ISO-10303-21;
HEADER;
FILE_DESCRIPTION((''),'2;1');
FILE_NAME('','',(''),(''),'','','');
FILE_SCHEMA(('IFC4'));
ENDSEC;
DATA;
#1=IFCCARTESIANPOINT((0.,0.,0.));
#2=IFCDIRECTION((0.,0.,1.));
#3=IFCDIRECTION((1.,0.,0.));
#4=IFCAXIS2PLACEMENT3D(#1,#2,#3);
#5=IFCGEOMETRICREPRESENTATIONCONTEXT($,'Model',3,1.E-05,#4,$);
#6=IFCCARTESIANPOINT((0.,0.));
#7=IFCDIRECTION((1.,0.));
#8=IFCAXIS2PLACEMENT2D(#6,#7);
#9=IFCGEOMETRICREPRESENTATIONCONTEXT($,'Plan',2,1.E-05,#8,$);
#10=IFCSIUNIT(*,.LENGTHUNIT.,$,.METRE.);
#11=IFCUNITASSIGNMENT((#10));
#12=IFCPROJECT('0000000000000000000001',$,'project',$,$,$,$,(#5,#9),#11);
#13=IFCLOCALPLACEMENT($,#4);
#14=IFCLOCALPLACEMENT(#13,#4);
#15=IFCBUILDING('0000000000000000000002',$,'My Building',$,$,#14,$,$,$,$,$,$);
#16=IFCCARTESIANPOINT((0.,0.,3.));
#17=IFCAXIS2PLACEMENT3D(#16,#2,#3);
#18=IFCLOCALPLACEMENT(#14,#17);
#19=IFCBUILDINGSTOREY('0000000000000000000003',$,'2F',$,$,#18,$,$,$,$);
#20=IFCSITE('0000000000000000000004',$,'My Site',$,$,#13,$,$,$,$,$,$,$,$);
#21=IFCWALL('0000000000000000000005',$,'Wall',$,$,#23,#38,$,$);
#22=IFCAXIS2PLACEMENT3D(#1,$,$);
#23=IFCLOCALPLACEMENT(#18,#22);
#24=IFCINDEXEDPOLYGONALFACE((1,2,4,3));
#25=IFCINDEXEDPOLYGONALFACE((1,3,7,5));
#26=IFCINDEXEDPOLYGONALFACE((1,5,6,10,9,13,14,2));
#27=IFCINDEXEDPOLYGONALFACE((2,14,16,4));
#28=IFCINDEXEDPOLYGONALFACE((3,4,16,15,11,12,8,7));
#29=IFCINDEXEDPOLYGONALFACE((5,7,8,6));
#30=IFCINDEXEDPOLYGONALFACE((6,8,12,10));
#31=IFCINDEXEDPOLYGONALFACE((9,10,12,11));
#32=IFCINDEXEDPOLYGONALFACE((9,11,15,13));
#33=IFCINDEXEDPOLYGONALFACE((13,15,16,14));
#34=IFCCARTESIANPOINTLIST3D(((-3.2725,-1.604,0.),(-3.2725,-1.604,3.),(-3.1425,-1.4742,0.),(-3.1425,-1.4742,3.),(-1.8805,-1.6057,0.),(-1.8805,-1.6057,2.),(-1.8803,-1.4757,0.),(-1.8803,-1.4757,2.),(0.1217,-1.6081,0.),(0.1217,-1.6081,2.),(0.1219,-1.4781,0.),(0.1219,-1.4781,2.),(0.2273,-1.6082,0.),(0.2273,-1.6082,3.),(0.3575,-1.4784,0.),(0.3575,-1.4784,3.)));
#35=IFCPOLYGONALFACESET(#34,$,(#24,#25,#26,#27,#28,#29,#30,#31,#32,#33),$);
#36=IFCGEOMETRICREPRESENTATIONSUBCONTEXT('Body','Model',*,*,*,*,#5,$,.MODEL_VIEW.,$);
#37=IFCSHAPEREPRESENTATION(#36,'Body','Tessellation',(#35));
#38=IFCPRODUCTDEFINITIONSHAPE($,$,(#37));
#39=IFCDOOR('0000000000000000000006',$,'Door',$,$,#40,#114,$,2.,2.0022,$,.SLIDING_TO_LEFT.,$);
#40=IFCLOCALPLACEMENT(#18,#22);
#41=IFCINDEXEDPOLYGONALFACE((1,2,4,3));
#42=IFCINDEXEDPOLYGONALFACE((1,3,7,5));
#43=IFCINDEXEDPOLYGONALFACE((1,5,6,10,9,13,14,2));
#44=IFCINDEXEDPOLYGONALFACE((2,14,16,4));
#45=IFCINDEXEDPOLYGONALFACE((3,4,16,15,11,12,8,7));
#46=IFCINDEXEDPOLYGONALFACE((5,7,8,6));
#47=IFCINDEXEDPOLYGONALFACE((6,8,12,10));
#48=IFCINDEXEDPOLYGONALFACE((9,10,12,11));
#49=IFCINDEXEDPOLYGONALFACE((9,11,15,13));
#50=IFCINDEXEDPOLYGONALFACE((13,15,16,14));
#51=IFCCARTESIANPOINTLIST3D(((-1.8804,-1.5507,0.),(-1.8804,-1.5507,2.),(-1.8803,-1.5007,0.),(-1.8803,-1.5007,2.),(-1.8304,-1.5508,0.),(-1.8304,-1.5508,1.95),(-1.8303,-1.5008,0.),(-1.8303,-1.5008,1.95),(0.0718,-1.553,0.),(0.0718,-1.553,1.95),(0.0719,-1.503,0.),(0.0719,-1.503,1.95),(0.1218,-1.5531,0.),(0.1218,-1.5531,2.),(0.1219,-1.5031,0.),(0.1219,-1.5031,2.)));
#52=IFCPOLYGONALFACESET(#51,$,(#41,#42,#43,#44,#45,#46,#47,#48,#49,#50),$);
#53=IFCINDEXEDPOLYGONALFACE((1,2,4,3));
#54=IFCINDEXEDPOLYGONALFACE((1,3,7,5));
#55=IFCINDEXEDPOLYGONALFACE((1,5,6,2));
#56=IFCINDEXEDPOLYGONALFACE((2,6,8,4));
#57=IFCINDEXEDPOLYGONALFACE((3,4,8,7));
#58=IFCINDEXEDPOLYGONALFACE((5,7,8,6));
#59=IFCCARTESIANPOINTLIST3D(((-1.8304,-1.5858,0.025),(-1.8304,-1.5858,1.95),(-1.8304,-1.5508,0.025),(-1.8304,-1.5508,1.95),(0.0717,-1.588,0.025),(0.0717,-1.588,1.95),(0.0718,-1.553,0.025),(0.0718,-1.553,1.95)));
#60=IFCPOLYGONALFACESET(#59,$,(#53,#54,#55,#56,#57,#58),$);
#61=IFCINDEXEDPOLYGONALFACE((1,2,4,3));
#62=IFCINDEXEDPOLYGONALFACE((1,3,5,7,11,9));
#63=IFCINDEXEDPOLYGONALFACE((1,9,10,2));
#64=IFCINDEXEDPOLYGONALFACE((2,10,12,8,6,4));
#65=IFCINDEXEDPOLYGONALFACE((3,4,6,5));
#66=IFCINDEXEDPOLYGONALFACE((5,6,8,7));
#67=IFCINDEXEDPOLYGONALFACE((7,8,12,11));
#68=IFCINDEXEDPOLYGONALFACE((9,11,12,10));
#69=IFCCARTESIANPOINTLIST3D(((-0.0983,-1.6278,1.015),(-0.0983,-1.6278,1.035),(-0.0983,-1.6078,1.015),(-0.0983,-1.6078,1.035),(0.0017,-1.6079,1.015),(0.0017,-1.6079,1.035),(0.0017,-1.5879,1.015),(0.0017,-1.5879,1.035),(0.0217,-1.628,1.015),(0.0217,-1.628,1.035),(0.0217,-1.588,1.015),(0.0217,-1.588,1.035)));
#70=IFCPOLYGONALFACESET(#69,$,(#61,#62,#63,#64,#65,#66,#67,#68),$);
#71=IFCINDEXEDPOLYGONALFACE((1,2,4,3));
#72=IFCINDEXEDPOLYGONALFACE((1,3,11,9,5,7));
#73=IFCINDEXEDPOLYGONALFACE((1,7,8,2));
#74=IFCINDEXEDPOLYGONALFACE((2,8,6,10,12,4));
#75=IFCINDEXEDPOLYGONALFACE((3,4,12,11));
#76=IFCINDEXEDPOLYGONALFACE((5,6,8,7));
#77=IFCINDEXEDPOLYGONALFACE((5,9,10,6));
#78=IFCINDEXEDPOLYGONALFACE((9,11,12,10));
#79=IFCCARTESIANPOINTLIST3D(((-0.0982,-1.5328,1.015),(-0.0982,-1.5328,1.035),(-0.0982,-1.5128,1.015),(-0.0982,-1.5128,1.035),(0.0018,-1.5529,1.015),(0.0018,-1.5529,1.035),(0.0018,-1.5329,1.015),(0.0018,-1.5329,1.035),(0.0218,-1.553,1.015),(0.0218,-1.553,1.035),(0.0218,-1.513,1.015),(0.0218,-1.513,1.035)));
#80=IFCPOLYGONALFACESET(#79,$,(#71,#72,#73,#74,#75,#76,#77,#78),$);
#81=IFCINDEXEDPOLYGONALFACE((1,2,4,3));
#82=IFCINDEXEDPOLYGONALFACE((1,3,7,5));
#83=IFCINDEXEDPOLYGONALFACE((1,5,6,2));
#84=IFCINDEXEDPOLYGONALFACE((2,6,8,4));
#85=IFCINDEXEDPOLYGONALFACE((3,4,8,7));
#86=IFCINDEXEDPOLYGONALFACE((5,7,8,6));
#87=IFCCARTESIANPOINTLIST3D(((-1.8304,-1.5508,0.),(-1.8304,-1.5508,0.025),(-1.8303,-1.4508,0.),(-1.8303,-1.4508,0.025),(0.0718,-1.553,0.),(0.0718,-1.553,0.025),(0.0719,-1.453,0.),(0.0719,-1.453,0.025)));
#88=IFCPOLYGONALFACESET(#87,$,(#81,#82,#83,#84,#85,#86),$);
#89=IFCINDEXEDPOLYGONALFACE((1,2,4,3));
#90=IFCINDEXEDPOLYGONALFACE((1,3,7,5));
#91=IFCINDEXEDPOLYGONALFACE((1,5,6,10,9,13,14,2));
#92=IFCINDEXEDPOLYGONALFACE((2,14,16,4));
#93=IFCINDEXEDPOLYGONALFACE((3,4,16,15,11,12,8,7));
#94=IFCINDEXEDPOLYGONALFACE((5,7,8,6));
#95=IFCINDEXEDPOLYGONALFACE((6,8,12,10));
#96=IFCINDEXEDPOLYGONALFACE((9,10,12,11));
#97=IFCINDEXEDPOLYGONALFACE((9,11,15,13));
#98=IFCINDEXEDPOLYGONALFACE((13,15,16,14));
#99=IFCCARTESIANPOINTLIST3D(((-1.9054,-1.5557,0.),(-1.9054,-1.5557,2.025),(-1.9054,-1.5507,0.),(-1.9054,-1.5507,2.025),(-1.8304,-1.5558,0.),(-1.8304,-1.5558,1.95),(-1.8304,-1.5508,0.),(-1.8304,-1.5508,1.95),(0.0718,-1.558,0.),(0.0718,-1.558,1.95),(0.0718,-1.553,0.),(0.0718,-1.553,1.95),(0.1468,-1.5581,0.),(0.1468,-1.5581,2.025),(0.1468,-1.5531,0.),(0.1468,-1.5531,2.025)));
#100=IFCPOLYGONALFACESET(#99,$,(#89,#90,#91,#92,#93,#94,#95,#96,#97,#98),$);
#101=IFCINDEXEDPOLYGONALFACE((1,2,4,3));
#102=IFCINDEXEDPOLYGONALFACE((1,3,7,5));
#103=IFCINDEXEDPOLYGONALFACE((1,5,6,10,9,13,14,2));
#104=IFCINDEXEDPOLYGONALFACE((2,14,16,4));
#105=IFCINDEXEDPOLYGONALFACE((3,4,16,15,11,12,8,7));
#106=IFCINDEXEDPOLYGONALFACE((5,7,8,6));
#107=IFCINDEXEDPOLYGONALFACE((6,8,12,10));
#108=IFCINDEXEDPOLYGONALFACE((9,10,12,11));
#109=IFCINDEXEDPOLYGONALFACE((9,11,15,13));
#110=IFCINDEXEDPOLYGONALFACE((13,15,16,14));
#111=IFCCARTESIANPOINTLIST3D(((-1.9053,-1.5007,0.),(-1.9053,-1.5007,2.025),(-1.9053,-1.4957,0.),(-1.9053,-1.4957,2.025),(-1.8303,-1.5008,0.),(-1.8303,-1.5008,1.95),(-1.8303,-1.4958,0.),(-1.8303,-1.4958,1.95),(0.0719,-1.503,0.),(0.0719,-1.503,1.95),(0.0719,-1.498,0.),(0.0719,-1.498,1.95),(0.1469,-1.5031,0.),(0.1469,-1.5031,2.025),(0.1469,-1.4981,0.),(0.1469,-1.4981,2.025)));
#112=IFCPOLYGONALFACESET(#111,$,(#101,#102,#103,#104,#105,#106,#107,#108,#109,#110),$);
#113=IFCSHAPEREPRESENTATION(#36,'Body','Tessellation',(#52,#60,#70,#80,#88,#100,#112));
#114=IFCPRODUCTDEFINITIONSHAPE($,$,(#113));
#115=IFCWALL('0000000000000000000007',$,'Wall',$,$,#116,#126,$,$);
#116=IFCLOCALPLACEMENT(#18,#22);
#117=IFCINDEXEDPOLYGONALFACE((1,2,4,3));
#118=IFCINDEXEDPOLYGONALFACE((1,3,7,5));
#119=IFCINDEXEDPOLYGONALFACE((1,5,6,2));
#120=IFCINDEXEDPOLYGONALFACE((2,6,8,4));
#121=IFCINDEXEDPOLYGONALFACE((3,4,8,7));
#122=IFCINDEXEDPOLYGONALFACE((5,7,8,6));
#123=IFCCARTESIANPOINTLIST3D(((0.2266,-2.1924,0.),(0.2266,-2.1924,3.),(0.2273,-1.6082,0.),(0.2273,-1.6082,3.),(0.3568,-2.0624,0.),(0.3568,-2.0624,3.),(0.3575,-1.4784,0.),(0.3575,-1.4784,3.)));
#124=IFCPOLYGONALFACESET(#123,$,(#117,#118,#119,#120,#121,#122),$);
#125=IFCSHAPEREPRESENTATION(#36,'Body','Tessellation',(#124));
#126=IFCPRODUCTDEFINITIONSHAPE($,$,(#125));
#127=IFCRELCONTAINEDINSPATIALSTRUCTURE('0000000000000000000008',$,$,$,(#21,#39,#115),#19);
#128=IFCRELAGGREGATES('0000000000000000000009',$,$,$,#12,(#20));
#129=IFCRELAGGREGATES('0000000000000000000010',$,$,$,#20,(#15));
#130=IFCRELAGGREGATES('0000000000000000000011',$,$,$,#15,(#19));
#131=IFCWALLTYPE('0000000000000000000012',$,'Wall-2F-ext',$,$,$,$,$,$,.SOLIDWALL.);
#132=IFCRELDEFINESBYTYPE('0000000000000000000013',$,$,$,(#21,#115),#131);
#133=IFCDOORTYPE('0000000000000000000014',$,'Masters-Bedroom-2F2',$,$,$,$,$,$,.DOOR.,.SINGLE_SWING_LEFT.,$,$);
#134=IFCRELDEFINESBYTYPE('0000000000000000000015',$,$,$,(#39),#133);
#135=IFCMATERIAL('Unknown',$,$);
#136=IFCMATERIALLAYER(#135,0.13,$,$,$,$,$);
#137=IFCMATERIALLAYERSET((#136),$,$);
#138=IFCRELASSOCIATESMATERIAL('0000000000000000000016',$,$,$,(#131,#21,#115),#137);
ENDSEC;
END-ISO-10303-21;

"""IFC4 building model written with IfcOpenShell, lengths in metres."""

from ifc_helpers import new_model, entity, si_unit, frame, origin_with_axes, origin_2d_with_axis, place, context, subcontext, project, spatial, line, indexed_curve, outline, extrude, shape, source, transform, mapped, material, layer, layer_set, layer_usage, type_object, type_shapes, element, fill, save


model = new_model("IFC4")

# Units and contexts
model_context = context("Model", 3, precision=1e-05, world=origin_with_axes())
plan_context = context("Plan", 2, precision=1e-05, world=origin_2d_with_axis())
body_context_1 = subcontext(model_context, "Body", "Model", "MODEL_VIEW")
body_context_2 = subcontext(plan_context, "Body", "Plan", "PLAN_VIEW")
ifc_project = project(units=[si_unit("LENGTHUNIT", "METRE")], contexts=[model_context, plan_context])

# Site, building, storey
site_placement = place(None, origin_with_axes())
site = spatial("IfcSite", under=ifc_project, at=site_placement, Name="My Site")
building_placement = place(site_placement, origin_with_axes())
building = spatial("IfcBuilding", under=site, at=building_placement, Name="My Building")
storey_placement = place(building_placement, frame((0.0, 0.0, 3.0), z_axis=(0.0, 0.0, 1.0), x_axis=(1.0, 0.0, 0.0)))
storey = spatial("IfcBuildingStorey", under=building, at=storey_placement, Name="2F")

# Shared definitions
ifc_material = material(Name="Unknown")

# Shared definitions
ifc_layer_1 = layer(ifc_material, 0.13)
ifc_layer_set_1 = layer_set([ifc_layer_1])
wall_type_1 = type_object("IfcWallType", Name="Wall-2F-ext", PredefinedType="SOLIDWALL", material=ifc_layer_set_1)

# Wall, opening, door
ifc_layer_usage_1 = layer_usage(ifc_layer_set_1, "AXIS2", "POSITIVE", 0.0)
wall_1_placement = place(storey_placement, frame((-3.2725, -1.604, 0.0), z_axis=(0.0, 0.0, 1.0), x_axis=(0.999999, -0.001194, 0.0)))
wall_1 = element("IfcWall", 1, at=wall_1_placement, inside=storey, type_object=wall_type_1, material=ifc_layer_usage_1, Name="Wall", context=body_context_1, shape_type="SweptSolid", body=[
    extrude(outline(indexed_curve([(0.0, 0.0), (0.1298, 0.13), (3.6298, 0.13), (3.4998, 0.0)], segments=[line(1, 2, 3, 4, 1)])), origin_with_axes(), (0.0, 0.0, 1.0), 3.0),
])
shared_shape_1 = source(origin_with_axes(), body_context_1, "Body", "SweptSolid", [
    extrude(outline(indexed_curve([(0.0, 0.0), (2.0022, 0.0), (2.0022, 2.0), (0.0, 2.0)], segments=[line(1, 2, 3, 4, 1)])), frame((0.0, -0.6, 0.0), z_axis=(0.0, -1.0, 0.0), x_axis=(1.0, 0.0, 0.0)), (0.0, 0.0, -1.0), 1.2),
])
opening_1_placement = place(wall_1_placement, frame((1.3921, 0.055, 0.0), z_axis=(0.0, 0.0, 1.0), x_axis=(1.0, 0.0, 0.0)))
opening_1 = element("IfcOpeningElement", 2, at=opening_1_placement, cuts=wall_1, PredefinedType="OPENING", context=body_context_1, shape_type="MappedRepresentation", body=[
    mapped(shared_shape_1, transform((0.0, 0.0, 0.0), x_axis=(1.0, 0.0, 0.0), y_axis=(0.0, 1.0, 0.0), z_axis=(0.0, 0.0, 1.0), scale=1.0)),
])
door_type_1 = type_object("IfcDoorType", Name="Masters-Bedroom-2F2", OperationType="SINGLE_SWING_LEFT", PredefinedType="DOOR")
shared_shape_2 = source(origin_with_axes(), body_context_1, "Body", "SweptSolid", [
    extrude(outline(indexed_curve([(0.0, 0.0), (0.0, 2.0), (2.0022, 2.0), (2.0022, 0.0), (1.9522, 0.0), (1.9522, 1.95), (0.05, 1.95), (0.05, 0.0)], segments=[line(1, 2, 3, 4, 5, 6, 7, 8, 1)])), frame((0.0, 0.0, 0.0), z_axis=(0.0, -1.0, 0.0), x_axis=(1.0, 0.0, 0.0)), (0.0, 0.0, -1.0), 0.05),
    extrude(outline(indexed_curve([(0.0, 0.0), (1.9022, 0.0), (1.9022, 0.035), (0.0, 0.035)], segments=[line(1, 2, 3, 4, 1)])), frame((0.05, -0.035, 0.025), z_axis=(0.0, 0.0, 1.0), x_axis=(1.0, 0.0, 0.0)), (0.0, 0.0, 1.0), 1.925),
    extrude(outline(indexed_curve([(0.0, 0.0), (0.0, -0.04), (-0.12, -0.04), (-0.12, -0.02), (-0.02, -0.02), (-0.02, 0.0)], segments=[line(1, 2, 3, 4, 5, 6, 1)])), frame((1.9022, -0.035, 1.015), z_axis=(0.0, 0.0, 1.0), x_axis=(1.0, 0.0, 0.0)), (0.0, 0.0, 1.0), 0.02),
    extrude(outline(indexed_curve([(0.0, 0.0), (0.0, 0.04), (-0.12, 0.04), (-0.12, 0.02), (-0.02, 0.02), (-0.02, 0.0)], segments=[line(1, 2, 3, 4, 5, 6, 1)])), frame((1.9022, 0.0, 1.015), z_axis=(0.0, 0.0, 1.0), x_axis=(1.0, 0.0, 0.0)), (0.0, 0.0, 1.0), 0.02),
    extrude(outline(indexed_curve([(0.0, 0.0), (1.9022, 0.0), (1.9022, 0.1), (0.0, 0.1)], segments=[line(1, 2, 3, 4, 1)])), frame((0.05, 0.0, 0.0), z_axis=(0.0, 0.0, 1.0), x_axis=(1.0, 0.0, 0.0)), (0.0, 0.0, 1.0), 0.025),
    extrude(outline(indexed_curve([(0.0, 0.0), (0.0, 2.025), (2.0522, 2.025), (2.0522, 0.0), (1.9772, 0.0), (1.9772, 1.95), (0.075, 1.95), (0.075, 0.0)], segments=[line(1, 2, 3, 4, 5, 6, 7, 8, 1)])), frame((-0.025, -0.005, 0.0), z_axis=(0.0, -1.0, 0.0), x_axis=(1.0, 0.0, 0.0)), (0.0, 0.0, -1.0), 0.005),
    extrude(outline(indexed_curve([(0.0, 0.0), (0.0, 2.025), (2.0522, 2.025), (2.0522, 0.0), (1.9772, 0.0), (1.9772, 1.95), (0.075, 1.95), (0.075, 0.0)], segments=[line(1, 2, 3, 4, 5, 6, 7, 8, 1)])), frame((-0.025, 0.05, 0.0), z_axis=(0.0, -1.0, 0.0), x_axis=(1.0, 0.0, 0.0)), (0.0, 0.0, -1.0), 0.005),
])
shared_shape_3 = source(origin_with_axes(), body_context_2, "Body", "Curve2D", [
    entity("IfcIndexedPolyCurve", entity("IfcCartesianPointList2D", [[0.0, 0.0], [0.05, 0.0], [0.05, 0.05], [0.0, 0.05]]), [entity("IfcLineIndex", [1, 2, 3, 4, 1])]),
    entity("IfcIndexedPolyCurve", entity("IfcCartesianPointList2D", [[2.0022, 0.0], [1.9522, 0.0], [1.9522, 0.05], [2.0022, 0.05]]), [entity("IfcLineIndex", [1, 2, 3, 4, 1])]),
    entity("IfcIndexedPolyCurve", entity("IfcCartesianPointList2D", [[-0.9011, -0.035], [1.0011, -0.035], [1.0011, 0.0], [-0.9011, 0.0]]), [entity("IfcLineIndex", [1, 2, 3, 4, 1])]),
])
type_shapes(door_type_1, [shared_shape_2, shared_shape_3])
door_1_placement = place(opening_1_placement, frame((0.0, 0.0, 0.0), z_axis=(0.0, 0.0, 1.0), x_axis=(1.0, 0.0, 0.0)))
door_1 = element("IfcDoor", 3, at=door_1_placement, inside=storey, type_object=door_type_1, Name="Door", OperationType="SLIDING_TO_LEFT", OverallHeight=2.0, OverallWidth=2.0022, shapes=[
    shape(body_context_1, "Body", "MappedRepresentation", [mapped(shared_shape_2, transform((0.0, 0.0, 0.0), x_axis=(1.0, 0.0, 0.0), y_axis=(0.0, 1.0, 0.0), z_axis=(0.0, 0.0, 1.0), scale=1.0))]),
    shape(body_context_2, "Body", "MappedRepresentation", [mapped(shared_shape_3, transform((0.0, 0.0, 0.0), x_axis=(1.0, 0.0, 0.0), y_axis=(0.0, 1.0, 0.0), z_axis=(0.0, 0.0, 1.0), scale=1.0))]),
])
fill(opening_1, door_1)

# Wall
ifc_layer_usage_2 = layer_usage(ifc_layer_set_1, "AXIS2", "POSITIVE", 0.0)
wall_2_placement = place(storey_placement, frame((0.2273, -1.6082, 0.0), z_axis=(0.0, 0.0, 1.0), x_axis=(-0.001194, -0.999999, 0.0)))
element("IfcWall", 4, at=wall_2_placement, inside=storey, type_object=wall_type_1, material=ifc_layer_usage_2, Name="Wall", context=body_context_1, shape_type="SweptSolid", body=[
    extrude(outline(indexed_curve([(0.0, 0.0), (-0.13, 0.13), (0.4541, 0.13), (0.5842, 0.0)], segments=[line(1, 2, 3, 4, 1)])), origin_with_axes(), (0.0, 0.0, 1.0), 3.0),
])

save(model, "model.ifc")
